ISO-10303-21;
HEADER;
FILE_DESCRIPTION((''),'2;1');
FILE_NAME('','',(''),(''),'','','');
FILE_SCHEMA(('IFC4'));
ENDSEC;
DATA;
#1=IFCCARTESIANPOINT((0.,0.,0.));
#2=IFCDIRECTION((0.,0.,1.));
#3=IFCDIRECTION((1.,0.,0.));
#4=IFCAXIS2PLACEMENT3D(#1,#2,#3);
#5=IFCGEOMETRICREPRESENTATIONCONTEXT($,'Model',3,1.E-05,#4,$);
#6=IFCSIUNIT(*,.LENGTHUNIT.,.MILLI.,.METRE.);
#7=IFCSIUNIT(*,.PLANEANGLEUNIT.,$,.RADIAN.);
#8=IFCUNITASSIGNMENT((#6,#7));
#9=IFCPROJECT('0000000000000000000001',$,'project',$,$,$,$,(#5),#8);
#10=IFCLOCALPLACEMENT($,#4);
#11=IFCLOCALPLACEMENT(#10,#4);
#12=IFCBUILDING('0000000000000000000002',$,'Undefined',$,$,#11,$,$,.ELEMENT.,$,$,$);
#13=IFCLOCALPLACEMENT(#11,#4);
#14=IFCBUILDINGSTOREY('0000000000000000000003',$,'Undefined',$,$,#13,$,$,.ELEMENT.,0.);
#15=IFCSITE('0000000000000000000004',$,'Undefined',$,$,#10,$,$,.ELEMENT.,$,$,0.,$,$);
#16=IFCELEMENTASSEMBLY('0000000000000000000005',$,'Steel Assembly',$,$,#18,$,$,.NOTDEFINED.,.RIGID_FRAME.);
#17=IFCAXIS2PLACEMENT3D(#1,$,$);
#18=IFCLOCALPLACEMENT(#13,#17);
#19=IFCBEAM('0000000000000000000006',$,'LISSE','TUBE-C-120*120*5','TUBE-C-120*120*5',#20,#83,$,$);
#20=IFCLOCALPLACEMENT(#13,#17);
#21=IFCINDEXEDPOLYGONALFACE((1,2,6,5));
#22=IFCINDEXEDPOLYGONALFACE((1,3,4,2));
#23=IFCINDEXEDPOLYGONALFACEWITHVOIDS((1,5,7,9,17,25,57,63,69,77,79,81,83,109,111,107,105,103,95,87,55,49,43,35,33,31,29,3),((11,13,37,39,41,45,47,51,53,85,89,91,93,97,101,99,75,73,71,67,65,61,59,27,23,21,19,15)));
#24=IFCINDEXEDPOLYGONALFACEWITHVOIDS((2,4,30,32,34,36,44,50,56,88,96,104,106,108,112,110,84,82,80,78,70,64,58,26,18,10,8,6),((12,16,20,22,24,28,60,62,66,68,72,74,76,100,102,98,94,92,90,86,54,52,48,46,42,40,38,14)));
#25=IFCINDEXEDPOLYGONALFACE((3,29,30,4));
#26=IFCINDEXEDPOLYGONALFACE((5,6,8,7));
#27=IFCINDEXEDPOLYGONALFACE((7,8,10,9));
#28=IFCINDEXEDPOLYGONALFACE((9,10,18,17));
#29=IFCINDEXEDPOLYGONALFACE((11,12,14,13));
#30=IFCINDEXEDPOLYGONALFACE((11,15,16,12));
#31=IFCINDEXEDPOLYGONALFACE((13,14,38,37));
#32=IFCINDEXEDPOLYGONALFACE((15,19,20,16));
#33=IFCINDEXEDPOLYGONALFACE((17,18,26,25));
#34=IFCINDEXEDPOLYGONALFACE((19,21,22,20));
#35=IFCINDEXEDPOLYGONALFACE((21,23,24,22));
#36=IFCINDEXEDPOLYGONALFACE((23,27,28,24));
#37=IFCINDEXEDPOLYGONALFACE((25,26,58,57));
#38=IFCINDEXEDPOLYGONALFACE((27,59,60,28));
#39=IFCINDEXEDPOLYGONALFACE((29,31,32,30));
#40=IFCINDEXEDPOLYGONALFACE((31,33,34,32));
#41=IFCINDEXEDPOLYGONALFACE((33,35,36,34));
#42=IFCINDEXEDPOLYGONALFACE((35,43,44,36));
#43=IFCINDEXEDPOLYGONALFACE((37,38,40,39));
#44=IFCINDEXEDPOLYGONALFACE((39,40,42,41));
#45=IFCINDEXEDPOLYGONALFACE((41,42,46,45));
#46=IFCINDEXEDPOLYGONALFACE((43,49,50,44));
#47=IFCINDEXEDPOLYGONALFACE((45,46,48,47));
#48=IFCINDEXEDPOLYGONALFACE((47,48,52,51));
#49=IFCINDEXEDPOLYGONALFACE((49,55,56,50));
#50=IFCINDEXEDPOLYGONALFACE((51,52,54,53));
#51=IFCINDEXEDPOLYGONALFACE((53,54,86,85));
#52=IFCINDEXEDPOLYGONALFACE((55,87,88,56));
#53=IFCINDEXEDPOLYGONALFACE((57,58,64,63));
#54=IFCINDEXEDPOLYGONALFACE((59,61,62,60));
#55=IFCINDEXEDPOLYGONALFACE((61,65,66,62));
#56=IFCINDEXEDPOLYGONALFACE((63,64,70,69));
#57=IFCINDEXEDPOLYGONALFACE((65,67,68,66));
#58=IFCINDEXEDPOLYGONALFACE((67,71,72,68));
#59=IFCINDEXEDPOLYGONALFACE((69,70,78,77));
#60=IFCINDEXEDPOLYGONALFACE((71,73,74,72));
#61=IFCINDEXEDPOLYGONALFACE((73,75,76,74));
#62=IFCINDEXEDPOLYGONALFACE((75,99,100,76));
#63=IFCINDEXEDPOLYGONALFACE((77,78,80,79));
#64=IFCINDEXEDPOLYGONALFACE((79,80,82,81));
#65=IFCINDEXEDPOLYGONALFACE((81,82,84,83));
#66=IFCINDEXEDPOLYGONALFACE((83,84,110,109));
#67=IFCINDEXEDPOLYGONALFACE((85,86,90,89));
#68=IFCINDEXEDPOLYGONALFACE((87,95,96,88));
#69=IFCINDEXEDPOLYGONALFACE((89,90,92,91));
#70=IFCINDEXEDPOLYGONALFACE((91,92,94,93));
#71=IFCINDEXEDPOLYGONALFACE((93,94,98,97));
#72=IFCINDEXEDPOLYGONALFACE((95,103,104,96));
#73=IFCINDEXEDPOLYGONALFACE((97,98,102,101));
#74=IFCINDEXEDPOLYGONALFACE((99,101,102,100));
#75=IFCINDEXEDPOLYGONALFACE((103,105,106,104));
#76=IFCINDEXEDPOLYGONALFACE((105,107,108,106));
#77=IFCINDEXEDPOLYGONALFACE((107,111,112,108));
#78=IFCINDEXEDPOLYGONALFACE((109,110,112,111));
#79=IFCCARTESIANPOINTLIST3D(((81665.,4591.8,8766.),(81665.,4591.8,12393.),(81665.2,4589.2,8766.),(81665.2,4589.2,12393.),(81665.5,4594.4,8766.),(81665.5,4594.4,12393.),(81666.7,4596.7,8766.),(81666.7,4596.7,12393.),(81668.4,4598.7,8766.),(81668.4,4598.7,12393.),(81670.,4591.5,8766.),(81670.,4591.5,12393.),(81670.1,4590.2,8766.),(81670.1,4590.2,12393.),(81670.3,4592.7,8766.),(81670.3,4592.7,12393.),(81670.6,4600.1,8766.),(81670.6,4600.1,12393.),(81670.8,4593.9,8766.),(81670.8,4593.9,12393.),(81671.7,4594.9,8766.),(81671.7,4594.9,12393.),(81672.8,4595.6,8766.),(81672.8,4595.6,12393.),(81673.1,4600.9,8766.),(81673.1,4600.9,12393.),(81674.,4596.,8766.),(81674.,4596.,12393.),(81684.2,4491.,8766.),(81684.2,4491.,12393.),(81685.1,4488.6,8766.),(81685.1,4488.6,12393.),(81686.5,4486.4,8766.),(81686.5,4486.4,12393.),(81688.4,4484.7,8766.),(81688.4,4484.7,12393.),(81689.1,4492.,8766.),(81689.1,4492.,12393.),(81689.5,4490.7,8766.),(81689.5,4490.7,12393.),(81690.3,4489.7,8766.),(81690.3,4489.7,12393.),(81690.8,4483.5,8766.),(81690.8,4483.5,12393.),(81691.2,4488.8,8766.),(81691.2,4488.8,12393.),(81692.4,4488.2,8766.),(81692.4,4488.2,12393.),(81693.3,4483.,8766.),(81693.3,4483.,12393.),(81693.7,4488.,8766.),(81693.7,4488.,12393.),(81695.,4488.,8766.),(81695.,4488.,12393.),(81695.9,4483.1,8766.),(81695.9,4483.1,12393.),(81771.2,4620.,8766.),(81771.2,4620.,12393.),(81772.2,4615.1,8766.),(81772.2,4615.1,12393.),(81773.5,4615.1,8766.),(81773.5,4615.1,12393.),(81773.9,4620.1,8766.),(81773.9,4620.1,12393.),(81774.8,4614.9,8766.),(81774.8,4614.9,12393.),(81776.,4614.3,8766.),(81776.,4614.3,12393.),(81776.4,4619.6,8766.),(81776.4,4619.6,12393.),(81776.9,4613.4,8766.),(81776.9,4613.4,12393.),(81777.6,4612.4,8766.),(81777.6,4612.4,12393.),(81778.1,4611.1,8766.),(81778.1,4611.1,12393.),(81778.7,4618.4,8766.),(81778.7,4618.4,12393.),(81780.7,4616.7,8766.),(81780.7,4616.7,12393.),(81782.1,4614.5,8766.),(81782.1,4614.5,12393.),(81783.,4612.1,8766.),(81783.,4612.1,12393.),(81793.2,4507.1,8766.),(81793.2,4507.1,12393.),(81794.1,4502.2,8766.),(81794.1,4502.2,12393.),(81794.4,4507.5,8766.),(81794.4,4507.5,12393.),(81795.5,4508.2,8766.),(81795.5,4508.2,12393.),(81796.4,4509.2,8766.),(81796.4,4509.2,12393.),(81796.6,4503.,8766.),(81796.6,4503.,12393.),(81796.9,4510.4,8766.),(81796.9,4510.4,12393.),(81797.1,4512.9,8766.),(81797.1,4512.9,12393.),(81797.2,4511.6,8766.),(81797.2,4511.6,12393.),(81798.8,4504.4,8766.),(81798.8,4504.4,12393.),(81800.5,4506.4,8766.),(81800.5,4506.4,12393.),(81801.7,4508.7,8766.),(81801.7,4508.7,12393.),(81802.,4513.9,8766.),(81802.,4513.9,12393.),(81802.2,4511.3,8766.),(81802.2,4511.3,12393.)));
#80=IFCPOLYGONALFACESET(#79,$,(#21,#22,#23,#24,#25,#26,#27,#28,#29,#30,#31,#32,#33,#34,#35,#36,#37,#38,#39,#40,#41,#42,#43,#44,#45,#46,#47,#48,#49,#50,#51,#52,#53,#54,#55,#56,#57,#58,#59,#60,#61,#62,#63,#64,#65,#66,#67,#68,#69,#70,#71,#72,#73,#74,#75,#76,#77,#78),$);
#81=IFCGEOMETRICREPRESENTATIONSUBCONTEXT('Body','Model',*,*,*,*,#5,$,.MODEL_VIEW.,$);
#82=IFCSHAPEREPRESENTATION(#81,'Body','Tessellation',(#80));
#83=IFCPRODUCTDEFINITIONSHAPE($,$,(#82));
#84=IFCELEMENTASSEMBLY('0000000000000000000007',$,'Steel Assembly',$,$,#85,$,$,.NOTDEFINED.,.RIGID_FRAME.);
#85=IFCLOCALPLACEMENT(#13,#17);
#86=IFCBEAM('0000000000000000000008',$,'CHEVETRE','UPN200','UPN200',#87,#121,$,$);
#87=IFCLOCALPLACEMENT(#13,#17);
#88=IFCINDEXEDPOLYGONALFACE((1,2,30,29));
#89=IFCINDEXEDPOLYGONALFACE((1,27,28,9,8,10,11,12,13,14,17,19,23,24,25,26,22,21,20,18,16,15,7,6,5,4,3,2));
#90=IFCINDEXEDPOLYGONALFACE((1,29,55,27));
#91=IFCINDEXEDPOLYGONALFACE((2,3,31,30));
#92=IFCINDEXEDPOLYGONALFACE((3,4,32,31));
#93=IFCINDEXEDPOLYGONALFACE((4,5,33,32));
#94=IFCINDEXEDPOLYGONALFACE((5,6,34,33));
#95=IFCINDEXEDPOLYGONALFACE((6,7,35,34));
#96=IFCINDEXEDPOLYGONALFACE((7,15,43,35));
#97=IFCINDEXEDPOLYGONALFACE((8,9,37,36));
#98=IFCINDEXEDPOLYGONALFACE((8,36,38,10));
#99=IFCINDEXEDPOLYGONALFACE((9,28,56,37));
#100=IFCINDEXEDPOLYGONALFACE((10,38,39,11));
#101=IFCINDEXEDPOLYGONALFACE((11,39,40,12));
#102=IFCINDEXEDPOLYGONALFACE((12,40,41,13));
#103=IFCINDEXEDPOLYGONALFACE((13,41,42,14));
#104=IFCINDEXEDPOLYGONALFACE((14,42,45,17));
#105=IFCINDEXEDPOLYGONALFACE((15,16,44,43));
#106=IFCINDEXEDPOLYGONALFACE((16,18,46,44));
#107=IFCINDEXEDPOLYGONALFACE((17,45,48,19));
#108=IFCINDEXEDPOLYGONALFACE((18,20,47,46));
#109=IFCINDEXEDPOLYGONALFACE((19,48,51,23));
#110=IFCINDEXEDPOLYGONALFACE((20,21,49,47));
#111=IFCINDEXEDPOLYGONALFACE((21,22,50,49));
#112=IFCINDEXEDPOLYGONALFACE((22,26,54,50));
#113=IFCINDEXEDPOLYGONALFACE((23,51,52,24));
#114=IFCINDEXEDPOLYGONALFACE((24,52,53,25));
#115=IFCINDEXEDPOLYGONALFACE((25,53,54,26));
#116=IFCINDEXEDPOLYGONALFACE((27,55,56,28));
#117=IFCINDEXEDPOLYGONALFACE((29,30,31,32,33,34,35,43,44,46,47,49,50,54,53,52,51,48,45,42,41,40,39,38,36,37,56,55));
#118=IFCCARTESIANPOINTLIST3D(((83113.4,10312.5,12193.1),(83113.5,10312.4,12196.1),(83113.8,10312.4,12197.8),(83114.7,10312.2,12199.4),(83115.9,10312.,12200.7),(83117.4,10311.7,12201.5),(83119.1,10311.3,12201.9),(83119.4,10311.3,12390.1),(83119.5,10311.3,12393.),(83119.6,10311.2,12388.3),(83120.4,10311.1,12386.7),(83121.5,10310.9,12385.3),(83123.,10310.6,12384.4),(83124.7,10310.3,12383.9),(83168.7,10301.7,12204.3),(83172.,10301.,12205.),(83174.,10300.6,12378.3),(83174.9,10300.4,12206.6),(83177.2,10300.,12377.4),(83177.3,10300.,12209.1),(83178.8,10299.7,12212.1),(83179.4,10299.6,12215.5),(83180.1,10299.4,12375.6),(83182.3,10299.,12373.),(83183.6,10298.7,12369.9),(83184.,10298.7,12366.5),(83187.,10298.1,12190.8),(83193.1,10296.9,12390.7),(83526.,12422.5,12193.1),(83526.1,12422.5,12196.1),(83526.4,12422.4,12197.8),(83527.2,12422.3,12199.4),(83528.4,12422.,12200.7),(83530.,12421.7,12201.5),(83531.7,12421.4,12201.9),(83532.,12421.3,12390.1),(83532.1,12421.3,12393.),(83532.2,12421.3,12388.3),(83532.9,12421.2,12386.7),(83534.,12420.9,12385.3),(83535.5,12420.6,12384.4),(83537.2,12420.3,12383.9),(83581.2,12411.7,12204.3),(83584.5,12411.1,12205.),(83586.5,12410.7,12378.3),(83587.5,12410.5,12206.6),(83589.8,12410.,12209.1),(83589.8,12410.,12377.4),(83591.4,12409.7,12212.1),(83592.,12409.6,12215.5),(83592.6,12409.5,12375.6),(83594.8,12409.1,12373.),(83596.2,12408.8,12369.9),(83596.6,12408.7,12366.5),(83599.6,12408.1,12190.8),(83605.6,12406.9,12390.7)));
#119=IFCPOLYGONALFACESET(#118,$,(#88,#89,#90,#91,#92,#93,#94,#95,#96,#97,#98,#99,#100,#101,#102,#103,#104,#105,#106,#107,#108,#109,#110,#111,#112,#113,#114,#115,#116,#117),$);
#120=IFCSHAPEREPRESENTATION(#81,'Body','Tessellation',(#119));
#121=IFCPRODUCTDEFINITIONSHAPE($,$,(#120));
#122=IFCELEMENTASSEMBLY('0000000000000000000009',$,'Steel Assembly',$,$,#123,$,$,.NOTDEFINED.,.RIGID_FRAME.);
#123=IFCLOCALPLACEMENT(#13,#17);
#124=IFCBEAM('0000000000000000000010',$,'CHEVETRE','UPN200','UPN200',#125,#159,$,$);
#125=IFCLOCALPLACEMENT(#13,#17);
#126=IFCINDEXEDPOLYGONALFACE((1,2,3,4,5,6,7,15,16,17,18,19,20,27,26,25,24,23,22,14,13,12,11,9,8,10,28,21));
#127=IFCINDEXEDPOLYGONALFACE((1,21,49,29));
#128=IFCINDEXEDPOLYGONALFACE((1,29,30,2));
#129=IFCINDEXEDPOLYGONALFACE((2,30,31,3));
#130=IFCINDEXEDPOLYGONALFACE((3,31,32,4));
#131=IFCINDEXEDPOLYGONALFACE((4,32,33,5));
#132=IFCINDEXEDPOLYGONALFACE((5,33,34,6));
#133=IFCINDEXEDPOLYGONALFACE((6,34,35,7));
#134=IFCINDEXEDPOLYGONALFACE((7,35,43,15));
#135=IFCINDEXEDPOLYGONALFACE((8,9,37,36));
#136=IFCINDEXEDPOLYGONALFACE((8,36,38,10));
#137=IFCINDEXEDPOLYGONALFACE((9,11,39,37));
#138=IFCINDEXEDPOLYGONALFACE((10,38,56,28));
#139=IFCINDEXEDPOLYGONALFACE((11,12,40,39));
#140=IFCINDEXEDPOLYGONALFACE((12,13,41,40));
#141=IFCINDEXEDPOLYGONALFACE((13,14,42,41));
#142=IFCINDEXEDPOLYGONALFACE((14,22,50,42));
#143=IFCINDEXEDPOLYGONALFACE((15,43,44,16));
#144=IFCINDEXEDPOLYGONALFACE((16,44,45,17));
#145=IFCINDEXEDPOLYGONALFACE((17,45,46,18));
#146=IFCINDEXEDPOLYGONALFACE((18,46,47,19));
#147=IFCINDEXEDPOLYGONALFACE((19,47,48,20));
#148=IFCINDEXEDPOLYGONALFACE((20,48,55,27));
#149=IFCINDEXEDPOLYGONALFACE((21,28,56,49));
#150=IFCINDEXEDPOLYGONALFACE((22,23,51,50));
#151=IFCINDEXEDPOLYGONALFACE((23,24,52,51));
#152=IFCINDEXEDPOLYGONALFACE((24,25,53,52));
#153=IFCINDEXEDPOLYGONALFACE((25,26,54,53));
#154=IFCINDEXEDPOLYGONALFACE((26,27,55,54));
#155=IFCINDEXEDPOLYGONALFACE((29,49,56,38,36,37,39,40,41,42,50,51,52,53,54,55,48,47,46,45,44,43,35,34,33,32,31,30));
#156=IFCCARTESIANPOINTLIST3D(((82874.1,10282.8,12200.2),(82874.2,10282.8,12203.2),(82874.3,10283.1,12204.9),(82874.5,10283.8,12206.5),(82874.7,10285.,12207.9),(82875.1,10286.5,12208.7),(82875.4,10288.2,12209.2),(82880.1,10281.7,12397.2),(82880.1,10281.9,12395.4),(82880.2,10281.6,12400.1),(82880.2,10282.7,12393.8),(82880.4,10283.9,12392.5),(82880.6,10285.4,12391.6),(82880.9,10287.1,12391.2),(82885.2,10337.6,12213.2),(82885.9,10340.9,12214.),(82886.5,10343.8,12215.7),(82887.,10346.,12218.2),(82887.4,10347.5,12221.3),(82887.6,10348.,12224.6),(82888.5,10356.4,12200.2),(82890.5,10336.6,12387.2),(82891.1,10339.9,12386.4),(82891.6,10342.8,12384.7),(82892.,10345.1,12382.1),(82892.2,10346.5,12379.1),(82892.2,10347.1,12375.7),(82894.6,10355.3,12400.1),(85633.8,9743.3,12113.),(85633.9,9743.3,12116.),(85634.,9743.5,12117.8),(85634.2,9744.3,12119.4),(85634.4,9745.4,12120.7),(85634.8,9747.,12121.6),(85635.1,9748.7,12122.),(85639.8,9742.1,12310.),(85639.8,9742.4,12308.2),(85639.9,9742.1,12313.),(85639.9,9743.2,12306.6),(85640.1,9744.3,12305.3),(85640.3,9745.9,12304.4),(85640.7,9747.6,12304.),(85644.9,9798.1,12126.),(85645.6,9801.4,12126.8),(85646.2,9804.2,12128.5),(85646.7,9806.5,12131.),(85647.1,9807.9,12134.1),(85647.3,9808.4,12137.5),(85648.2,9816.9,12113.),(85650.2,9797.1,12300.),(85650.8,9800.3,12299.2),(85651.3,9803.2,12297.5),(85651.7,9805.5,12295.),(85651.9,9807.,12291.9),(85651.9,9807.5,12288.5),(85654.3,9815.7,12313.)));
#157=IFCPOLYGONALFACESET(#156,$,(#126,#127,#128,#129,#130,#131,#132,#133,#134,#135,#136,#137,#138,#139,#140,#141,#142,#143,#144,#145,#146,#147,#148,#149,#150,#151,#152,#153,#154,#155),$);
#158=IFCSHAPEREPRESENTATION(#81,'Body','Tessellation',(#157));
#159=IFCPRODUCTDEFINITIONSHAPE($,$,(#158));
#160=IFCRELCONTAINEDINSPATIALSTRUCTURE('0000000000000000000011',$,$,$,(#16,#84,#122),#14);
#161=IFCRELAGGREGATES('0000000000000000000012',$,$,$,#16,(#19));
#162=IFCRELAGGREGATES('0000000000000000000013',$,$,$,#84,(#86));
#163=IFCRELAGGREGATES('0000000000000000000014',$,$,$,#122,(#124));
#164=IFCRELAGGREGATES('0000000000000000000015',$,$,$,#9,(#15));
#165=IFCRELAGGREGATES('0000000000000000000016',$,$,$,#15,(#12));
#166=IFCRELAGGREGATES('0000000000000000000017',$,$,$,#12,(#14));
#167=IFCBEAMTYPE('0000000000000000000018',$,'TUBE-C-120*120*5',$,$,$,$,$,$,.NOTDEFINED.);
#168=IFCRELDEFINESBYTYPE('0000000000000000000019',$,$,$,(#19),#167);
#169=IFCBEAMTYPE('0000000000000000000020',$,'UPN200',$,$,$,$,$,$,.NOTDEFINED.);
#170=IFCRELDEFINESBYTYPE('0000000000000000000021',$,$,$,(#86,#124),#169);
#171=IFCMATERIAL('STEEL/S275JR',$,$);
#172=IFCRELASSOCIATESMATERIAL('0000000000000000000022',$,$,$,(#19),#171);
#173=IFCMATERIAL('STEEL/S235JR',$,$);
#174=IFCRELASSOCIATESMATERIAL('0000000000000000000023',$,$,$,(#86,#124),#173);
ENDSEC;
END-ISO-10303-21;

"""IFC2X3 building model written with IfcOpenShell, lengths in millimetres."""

from ifc_helpers import new_model, si_unit, frame, origin_with_axes, origin_2d_with_axis, place, context, subcontext, project, spatial, hollow_rectangle, u_section, extrude, material, type_object, element, aggregate, save


model = new_model("IFC2X3")

# Units and contexts
model_context = context("Model", 3, precision=1e-05, world=origin_with_axes())
body_context = subcontext(model_context, "Body", "Model", "MODEL_VIEW")
ifc_project = project(units=[si_unit("LENGTHUNIT", "METRE", prefix="MILLI"), si_unit("PLANEANGLEUNIT", "RADIAN")], contexts=[model_context])

# Site, building, storey
site_placement = place(None, origin_with_axes())
site = spatial("IfcSite", under=ifc_project, at=site_placement, Name="Undefined", CompositionType="ELEMENT", RefElevation=0.0)
building_placement = place(site_placement, origin_with_axes())
building = spatial("IfcBuilding", under=site, at=building_placement, Name="Undefined", CompositionType="ELEMENT")
storey_placement = place(building_placement, origin_with_axes())
storey = spatial("IfcBuildingStorey", under=building, at=storey_placement, Name="Undefined", CompositionType="ELEMENT", Elevation=0.0)

# Element assemblies, beams
ifc_material_1 = material(Name="STEEL/S275JR")
beam_type_1 = type_object("IfcBeamType", Name="TUBE-C-120*120*5", PredefinedType="NOTDEFINED")
assembly_1_placement = place(storey_placement, origin_with_axes())
assembly_1 = element("IfcElementAssembly", 1, at=assembly_1_placement, inside=storey, Name="Steel Assembly", AssemblyPlace="NOTDEFINED", PredefinedType="RIGID_FRAME")
beam_1_placement = place(assembly_1_placement, frame((81733.6, 4551.6, 12393.0), z_axis=(0.190528, -0.981682, 0.0), x_axis=(0.0, 0.0, -1.0)))
beam_1 = element("IfcBeam", 2, at=beam_1_placement, type_object=beam_type_1, material=ifc_material_1, Name="LISSE", Description="TUBE-C-120*120*5", ObjectType="TUBE-C-120*120*5", context=body_context, shape_type="SweptSolid", body=[
    extrude(hollow_rectangle(XDim=120.0, YDim=120.0, WallThickness=5.0, InnerFilletRadius=5.0, OuterFilletRadius=10.0, at=origin_2d_with_axis()), frame((3627.0, 0.0, 0.0), z_axis=(-1.0, 0.0, 0.0), x_axis=(0.0, -1.0, 0.0)), (0.0, 0.0, 1.0), 3627.0),
])
aggregate(assembly_1, [beam_1])
assembly_2_placement = place(storey_placement, origin_with_axes())
assembly_2 = element("IfcElementAssembly", 3, at=assembly_2_placement, inside=storey, Name="Steel Assembly", AssemblyPlace="NOTDEFINED", PredefinedType="RIGID_FRAME")
ifc_material_2 = material(Name="STEEL/S235JR")
beam_type_2 = type_object("IfcBeamType", Name="UPN200", PredefinedType="NOTDEFINED")
beam_2_placement = place(assembly_2_placement, frame((83565.8, 12414.7, 12291.9), z_axis=(0.030408, -0.005945, 0.99952), x_axis=(-0.191877, -0.981419, 0.0)))
beam_2 = element("IfcBeam", 4, at=beam_2_placement, type_object=beam_type_2, material=ifc_material_2, Name="CHEVETRE", Description="UPN200", ObjectType="UPN200", context=body_context, shape_type="SweptSolid", body=[
    extrude(u_section(Depth=200.0, FlangeWidth=75.0, WebThickness=8.5, FlangeThickness=11.5, FilletRadius=11.5, EdgeRadius=6.0, FlangeSlope=0.07983, at=origin_2d_with_axis()), frame((2150.0, 0.0, 0.0), z_axis=(-1.0, 0.0, 0.0), x_axis=(0.0, -1.0, 0.0)), (0.0, 0.0, 1.0), 2150.0),
])
aggregate(assembly_2, [beam_2])
assembly_3_placement = place(storey_placement, origin_with_axes())
assembly_3 = element("IfcElementAssembly", 5, at=assembly_3_placement, inside=storey, Name="Steel Assembly", AssemblyPlace="NOTDEFINED", PredefinedType="RIGID_FRAME")
beam_3_placement = place(assembly_3_placement, frame((82884.3, 10319.0, 12300.2), z_axis=(0.030408, -0.005945, 0.99952), x_axis=(0.980948, -0.191783, -0.030984)))
beam_3 = element("IfcBeam", 6, at=beam_3_placement, type_object=beam_type_2, material=ifc_material_2, Name="CHEVETRE", Description="UPN200", ObjectType="UPN200", context=body_context, shape_type="SweptSolid", body=[
    extrude(u_section(Depth=200.0, FlangeWidth=75.0, WebThickness=8.5, FlangeThickness=11.5, FilletRadius=11.5, EdgeRadius=6.0, FlangeSlope=0.07983, at=origin_2d_with_axis()), frame((2813.3, 0.0, 0.0), z_axis=(-1.0, 0.0, 0.0), x_axis=(0.0, -1.0, 0.0)), (0.0, 0.0, 1.0), 2813.3),
])
aggregate(assembly_3, [beam_3])

save(model, "model.ifc")
